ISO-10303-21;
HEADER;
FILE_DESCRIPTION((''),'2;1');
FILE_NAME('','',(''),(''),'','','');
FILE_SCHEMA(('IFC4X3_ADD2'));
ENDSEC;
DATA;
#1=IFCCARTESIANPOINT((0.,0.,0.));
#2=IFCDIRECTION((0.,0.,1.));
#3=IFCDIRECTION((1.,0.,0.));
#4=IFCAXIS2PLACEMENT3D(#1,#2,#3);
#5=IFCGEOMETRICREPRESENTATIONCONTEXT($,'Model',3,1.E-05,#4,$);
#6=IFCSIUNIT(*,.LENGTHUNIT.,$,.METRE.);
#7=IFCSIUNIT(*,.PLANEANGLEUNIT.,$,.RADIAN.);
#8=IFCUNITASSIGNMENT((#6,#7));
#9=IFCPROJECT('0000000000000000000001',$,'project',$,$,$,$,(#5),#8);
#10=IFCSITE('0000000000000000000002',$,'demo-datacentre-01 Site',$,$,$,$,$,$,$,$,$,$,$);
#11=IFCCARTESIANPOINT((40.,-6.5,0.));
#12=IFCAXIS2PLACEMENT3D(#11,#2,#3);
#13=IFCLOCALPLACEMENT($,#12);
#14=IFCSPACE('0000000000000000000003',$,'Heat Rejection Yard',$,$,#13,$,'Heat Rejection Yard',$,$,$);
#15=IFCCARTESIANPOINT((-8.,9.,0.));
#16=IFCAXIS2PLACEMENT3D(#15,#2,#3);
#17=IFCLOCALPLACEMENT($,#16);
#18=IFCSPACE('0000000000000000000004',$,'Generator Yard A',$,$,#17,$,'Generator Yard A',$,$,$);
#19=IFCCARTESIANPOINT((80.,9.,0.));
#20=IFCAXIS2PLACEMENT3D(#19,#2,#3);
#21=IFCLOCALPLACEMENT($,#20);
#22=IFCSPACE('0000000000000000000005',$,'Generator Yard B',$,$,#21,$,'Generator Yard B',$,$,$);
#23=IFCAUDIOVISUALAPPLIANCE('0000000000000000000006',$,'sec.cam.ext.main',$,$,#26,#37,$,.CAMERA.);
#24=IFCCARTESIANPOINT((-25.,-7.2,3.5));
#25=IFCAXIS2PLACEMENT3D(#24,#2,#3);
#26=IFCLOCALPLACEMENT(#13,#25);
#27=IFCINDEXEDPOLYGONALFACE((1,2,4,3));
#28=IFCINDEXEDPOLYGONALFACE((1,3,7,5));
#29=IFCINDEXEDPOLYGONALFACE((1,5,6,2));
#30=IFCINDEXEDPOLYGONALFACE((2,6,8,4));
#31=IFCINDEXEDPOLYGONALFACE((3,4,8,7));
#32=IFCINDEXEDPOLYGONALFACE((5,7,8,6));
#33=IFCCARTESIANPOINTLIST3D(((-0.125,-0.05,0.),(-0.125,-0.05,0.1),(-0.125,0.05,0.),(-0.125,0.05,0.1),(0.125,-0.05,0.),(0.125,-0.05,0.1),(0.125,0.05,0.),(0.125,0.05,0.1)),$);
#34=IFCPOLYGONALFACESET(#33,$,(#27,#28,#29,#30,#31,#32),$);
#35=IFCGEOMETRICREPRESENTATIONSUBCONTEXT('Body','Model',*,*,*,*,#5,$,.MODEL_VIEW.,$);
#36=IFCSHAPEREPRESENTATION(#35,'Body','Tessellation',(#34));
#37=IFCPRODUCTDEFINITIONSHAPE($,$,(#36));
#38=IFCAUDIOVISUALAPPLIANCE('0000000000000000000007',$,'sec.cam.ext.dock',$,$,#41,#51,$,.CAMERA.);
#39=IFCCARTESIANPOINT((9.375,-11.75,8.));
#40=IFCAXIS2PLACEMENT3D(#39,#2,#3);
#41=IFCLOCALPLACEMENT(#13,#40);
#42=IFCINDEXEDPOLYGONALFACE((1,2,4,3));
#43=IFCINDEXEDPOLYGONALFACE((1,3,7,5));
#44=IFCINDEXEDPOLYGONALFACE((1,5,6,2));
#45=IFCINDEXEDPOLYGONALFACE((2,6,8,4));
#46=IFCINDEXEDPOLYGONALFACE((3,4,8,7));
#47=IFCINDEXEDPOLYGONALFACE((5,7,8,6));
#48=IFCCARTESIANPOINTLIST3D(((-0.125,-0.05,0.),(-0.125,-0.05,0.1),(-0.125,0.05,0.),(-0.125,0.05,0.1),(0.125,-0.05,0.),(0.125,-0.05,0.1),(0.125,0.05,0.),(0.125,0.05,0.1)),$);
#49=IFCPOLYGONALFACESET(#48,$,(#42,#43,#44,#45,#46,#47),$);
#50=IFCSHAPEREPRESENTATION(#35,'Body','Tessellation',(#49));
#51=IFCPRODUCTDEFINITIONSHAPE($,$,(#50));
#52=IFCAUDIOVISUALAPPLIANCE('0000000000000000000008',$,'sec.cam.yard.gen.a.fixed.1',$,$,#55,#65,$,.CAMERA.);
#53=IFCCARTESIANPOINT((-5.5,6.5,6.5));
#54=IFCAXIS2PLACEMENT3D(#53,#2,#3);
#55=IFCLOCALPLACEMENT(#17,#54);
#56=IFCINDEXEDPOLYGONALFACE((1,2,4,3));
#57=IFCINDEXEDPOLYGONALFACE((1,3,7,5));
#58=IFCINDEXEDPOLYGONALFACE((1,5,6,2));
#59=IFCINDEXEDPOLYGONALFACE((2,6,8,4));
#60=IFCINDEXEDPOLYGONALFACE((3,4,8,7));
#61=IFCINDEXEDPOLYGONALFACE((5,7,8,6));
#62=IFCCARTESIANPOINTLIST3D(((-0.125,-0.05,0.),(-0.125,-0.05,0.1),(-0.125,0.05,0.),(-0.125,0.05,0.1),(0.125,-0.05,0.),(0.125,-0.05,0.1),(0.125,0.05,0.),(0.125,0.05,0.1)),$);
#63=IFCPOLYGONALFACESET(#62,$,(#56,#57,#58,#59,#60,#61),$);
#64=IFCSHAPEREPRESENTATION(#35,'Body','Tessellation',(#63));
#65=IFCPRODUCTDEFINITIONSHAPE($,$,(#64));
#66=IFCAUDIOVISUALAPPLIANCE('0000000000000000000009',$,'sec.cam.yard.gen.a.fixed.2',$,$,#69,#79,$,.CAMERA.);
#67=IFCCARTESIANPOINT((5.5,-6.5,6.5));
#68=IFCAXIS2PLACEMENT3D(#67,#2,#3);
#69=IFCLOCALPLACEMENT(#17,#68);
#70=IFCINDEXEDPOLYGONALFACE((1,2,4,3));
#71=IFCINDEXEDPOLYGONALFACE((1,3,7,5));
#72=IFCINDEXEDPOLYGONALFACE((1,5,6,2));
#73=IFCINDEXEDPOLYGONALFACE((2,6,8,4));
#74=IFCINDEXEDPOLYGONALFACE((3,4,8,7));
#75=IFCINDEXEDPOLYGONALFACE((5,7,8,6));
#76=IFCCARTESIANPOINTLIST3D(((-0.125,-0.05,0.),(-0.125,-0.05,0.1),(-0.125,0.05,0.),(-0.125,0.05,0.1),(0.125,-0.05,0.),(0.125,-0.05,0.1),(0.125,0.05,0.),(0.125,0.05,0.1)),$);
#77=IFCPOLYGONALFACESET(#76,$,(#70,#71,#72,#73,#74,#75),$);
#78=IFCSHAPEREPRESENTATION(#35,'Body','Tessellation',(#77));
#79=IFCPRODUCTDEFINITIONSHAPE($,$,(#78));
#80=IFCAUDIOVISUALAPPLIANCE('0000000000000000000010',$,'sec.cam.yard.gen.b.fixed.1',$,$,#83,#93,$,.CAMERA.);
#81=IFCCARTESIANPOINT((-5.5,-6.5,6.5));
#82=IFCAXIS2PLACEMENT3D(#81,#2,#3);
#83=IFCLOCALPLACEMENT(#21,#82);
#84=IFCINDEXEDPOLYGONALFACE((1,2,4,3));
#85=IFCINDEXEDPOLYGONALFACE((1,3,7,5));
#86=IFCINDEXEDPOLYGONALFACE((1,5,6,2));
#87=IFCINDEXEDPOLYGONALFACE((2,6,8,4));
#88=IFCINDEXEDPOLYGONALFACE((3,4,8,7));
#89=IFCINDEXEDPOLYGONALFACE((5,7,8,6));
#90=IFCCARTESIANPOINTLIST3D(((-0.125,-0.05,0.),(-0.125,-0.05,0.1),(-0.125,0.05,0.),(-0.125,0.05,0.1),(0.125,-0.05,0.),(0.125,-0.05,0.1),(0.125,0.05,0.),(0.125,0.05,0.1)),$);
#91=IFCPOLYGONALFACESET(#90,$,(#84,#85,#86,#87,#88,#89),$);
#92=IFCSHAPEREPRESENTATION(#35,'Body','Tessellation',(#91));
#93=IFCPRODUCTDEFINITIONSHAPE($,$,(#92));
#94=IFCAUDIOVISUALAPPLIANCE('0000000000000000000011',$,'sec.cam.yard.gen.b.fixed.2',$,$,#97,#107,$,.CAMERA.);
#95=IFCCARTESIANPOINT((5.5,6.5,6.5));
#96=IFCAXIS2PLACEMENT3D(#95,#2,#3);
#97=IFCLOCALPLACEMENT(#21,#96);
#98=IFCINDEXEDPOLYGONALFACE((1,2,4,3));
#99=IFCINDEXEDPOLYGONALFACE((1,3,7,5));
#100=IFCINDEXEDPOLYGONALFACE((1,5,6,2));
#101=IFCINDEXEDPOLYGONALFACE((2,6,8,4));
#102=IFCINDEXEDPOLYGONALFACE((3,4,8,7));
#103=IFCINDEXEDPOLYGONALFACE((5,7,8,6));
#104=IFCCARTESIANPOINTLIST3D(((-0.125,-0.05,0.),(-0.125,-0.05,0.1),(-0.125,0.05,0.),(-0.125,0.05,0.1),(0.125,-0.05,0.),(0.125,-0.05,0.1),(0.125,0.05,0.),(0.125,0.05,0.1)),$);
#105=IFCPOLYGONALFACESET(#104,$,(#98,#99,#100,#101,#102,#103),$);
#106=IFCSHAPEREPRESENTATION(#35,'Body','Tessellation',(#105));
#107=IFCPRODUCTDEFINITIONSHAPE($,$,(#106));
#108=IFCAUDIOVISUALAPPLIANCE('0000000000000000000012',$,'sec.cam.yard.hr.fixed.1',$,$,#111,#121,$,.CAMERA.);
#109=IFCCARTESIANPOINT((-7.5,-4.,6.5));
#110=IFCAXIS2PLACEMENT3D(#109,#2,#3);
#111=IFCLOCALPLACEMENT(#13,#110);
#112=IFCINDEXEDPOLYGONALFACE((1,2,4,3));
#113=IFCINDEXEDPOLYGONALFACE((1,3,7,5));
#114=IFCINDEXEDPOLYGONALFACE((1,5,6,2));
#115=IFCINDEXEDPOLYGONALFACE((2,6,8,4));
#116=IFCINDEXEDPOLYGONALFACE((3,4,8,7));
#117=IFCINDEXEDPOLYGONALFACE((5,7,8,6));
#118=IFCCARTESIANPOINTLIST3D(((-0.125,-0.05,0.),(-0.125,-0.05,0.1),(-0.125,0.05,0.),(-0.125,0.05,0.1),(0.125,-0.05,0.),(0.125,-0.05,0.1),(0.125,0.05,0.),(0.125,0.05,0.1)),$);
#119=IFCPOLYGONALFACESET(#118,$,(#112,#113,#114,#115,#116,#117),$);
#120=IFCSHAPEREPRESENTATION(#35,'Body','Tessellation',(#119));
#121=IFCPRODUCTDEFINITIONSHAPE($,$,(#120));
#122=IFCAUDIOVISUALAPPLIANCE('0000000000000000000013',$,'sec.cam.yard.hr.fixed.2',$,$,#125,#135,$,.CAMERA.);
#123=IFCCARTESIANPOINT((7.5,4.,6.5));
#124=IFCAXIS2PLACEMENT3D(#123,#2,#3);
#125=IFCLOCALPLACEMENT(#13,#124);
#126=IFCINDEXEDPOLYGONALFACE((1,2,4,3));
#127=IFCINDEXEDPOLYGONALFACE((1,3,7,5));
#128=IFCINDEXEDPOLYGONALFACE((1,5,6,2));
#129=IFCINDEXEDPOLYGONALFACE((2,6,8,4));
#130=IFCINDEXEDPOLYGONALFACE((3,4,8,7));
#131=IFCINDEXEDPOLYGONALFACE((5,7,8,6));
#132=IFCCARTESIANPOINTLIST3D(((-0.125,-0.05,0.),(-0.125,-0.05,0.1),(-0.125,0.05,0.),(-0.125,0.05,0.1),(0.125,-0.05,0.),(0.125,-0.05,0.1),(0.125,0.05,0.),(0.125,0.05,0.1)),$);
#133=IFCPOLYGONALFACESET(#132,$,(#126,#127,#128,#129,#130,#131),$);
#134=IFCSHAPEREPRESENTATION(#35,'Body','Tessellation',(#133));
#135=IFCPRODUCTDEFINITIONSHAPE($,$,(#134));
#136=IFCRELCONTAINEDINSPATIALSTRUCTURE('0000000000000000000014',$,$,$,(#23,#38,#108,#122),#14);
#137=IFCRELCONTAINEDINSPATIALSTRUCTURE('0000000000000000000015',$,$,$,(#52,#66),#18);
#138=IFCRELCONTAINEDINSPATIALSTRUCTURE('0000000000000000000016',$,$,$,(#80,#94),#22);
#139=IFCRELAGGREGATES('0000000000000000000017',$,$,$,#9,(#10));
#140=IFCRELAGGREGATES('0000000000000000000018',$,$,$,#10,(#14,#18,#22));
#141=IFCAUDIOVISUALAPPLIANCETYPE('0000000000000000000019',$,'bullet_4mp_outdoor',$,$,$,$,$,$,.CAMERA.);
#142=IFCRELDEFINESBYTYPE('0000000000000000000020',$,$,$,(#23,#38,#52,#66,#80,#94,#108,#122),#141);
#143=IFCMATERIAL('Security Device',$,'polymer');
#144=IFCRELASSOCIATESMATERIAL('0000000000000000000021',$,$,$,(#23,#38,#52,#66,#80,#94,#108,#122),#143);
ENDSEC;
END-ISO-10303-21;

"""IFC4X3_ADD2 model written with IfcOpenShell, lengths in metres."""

from ifc_helpers import new_model, si_unit, frame, origin_with_axes, place, context, subcontext, project, spatial, rectangle, extrude, source, transform, mapped, material, type_object, type_shapes, element, save


model = new_model("IFC4X3_ADD2")

# Units and contexts
model_context = context("Model", 3, precision=1e-05, world=origin_with_axes())
body_context = subcontext(model_context, "Body", "Model", "MODEL_VIEW")
ifc_project = project(units=[si_unit("LENGTHUNIT", "METRE"), si_unit("PLANEANGLEUNIT", "RADIAN")], contexts=[model_context])

# Site, space
site = spatial("IfcSite", under=ifc_project, Name="demo-datacentre-01 Site")
space_1_placement = place(None, frame((40.0, -6.5, 0.0), z_axis=(0.0, 0.0, 1.0), x_axis=(1.0, 0.0, 0.0)))
space_1 = spatial("IfcSpace", under=site, at=space_1_placement, Name="Heat Rejection Yard", LongName="Heat Rejection Yard")

# Audio visual appliances
ifc_material = material(Name="Security Device", Category="polymer")
audio_visual_appliance_type_1 = type_object("IfcAudioVisualApplianceType", Name="bullet_4mp_outdoor", PredefinedType="CAMERA")
shared_shape_1 = source(origin_with_axes(), body_context, "Body", "SweptSolid", [
    extrude(rectangle(XDim=0.25, YDim=0.1), origin_with_axes(), (0.0, 0.0, 1.0), 0.1),
])
type_shapes(audio_visual_appliance_type_1, [shared_shape_1])
for number, where, z_axis, x_axis, name in (
    (1, (-25.0, -7.2, 3.5), (0.0, 0.0, 1.0), (1.0, 0.0, 0.0), "sec.cam.ext.main"),
    (2, (9.375, -11.75, 8.0), (0.0, 0.0, 1.0), (1.0, 0.0, 0.0), "sec.cam.ext.dock"),
):
    element("IfcAudioVisualAppliance", number, at=place(space_1_placement, frame(where, z_axis=z_axis, x_axis=x_axis)), inside=space_1, type_object=audio_visual_appliance_type_1, material=ifc_material, Name=name, PredefinedType="CAMERA", context=body_context, shape_type="MappedRepresentation", body=[
        mapped(shared_shape_1, transform((0.0, 0.0, 0.0), x_axis=(1.0, 0.0, 0.0), y_axis=(0.0, 1.0, 0.0), z_axis=(0.0, 0.0, 1.0), scale=1.0)),
    ])

# Shared definitions
space_2_placement = place(None, frame((-8.0, 9.0, 0.0), z_axis=(0.0, 0.0, 1.0), x_axis=(1.0, 0.0, 0.0)))
space_2 = spatial("IfcSpace", under=site, at=space_2_placement, Name="Generator Yard A", LongName="Generator Yard A")

# Shared definitions
space_3_placement = place(None, frame((80.0, 9.0, 0.0), z_axis=(0.0, 0.0, 1.0), x_axis=(1.0, 0.0, 0.0)))
space_3 = spatial("IfcSpace", under=site, at=space_3_placement, Name="Generator Yard B", LongName="Generator Yard B")

# Audio visual appliances
for number, where, z_axis, x_axis, name in (
    (3, (-5.5, 6.5, 6.5), (0.0, 0.0, 1.0), (1.0, 0.0, 0.0), "sec.cam.yard.gen.a.fixed.1"),
    (4, (5.5, -6.5, 6.5), (0.0, 0.0, 1.0), (1.0, 0.0, 0.0), "sec.cam.yard.gen.a.fixed.2"),
):
    element("IfcAudioVisualAppliance", number, at=place(space_2_placement, frame(where, z_axis=z_axis, x_axis=x_axis)), inside=space_2, type_object=audio_visual_appliance_type_1, material=ifc_material, Name=name, PredefinedType="CAMERA", context=body_context, shape_type="MappedRepresentation", body=[
        mapped(shared_shape_1, transform((0.0, 0.0, 0.0), x_axis=(1.0, 0.0, 0.0), y_axis=(0.0, 1.0, 0.0), z_axis=(0.0, 0.0, 1.0), scale=1.0)),
    ])
for number, where, z_axis, x_axis, name in (
    (5, (-5.5, -6.5, 6.5), (0.0, 0.0, 1.0), (1.0, 0.0, 0.0), "sec.cam.yard.gen.b.fixed.1"),
    (6, (5.5, 6.5, 6.5), (0.0, 0.0, 1.0), (1.0, 0.0, 0.0), "sec.cam.yard.gen.b.fixed.2"),
):
    element("IfcAudioVisualAppliance", number, at=place(space_3_placement, frame(where, z_axis=z_axis, x_axis=x_axis)), inside=space_3, type_object=audio_visual_appliance_type_1, material=ifc_material, Name=name, PredefinedType="CAMERA", context=body_context, shape_type="MappedRepresentation", body=[
        mapped(shared_shape_1, transform((0.0, 0.0, 0.0), x_axis=(1.0, 0.0, 0.0), y_axis=(0.0, 1.0, 0.0), z_axis=(0.0, 0.0, 1.0), scale=1.0)),
    ])
for number, where, z_axis, x_axis, name in (
    (7, (-7.5, -4.0, 6.5), (0.0, 0.0, 1.0), (1.0, 0.0, 0.0), "sec.cam.yard.hr.fixed.1"),
    (8, (7.5, 4.0, 6.5), (0.0, 0.0, 1.0), (1.0, 0.0, 0.0), "sec.cam.yard.hr.fixed.2"),
):
    element("IfcAudioVisualAppliance", number, at=place(space_1_placement, frame(where, z_axis=z_axis, x_axis=x_axis)), inside=space_1, type_object=audio_visual_appliance_type_1, material=ifc_material, Name=name, PredefinedType="CAMERA", context=body_context, shape_type="MappedRepresentation", body=[
        mapped(shared_shape_1, transform((0.0, 0.0, 0.0), x_axis=(1.0, 0.0, 0.0), y_axis=(0.0, 1.0, 0.0), z_axis=(0.0, 0.0, 1.0), scale=1.0)),
    ])

save(model, "model.ifc")
